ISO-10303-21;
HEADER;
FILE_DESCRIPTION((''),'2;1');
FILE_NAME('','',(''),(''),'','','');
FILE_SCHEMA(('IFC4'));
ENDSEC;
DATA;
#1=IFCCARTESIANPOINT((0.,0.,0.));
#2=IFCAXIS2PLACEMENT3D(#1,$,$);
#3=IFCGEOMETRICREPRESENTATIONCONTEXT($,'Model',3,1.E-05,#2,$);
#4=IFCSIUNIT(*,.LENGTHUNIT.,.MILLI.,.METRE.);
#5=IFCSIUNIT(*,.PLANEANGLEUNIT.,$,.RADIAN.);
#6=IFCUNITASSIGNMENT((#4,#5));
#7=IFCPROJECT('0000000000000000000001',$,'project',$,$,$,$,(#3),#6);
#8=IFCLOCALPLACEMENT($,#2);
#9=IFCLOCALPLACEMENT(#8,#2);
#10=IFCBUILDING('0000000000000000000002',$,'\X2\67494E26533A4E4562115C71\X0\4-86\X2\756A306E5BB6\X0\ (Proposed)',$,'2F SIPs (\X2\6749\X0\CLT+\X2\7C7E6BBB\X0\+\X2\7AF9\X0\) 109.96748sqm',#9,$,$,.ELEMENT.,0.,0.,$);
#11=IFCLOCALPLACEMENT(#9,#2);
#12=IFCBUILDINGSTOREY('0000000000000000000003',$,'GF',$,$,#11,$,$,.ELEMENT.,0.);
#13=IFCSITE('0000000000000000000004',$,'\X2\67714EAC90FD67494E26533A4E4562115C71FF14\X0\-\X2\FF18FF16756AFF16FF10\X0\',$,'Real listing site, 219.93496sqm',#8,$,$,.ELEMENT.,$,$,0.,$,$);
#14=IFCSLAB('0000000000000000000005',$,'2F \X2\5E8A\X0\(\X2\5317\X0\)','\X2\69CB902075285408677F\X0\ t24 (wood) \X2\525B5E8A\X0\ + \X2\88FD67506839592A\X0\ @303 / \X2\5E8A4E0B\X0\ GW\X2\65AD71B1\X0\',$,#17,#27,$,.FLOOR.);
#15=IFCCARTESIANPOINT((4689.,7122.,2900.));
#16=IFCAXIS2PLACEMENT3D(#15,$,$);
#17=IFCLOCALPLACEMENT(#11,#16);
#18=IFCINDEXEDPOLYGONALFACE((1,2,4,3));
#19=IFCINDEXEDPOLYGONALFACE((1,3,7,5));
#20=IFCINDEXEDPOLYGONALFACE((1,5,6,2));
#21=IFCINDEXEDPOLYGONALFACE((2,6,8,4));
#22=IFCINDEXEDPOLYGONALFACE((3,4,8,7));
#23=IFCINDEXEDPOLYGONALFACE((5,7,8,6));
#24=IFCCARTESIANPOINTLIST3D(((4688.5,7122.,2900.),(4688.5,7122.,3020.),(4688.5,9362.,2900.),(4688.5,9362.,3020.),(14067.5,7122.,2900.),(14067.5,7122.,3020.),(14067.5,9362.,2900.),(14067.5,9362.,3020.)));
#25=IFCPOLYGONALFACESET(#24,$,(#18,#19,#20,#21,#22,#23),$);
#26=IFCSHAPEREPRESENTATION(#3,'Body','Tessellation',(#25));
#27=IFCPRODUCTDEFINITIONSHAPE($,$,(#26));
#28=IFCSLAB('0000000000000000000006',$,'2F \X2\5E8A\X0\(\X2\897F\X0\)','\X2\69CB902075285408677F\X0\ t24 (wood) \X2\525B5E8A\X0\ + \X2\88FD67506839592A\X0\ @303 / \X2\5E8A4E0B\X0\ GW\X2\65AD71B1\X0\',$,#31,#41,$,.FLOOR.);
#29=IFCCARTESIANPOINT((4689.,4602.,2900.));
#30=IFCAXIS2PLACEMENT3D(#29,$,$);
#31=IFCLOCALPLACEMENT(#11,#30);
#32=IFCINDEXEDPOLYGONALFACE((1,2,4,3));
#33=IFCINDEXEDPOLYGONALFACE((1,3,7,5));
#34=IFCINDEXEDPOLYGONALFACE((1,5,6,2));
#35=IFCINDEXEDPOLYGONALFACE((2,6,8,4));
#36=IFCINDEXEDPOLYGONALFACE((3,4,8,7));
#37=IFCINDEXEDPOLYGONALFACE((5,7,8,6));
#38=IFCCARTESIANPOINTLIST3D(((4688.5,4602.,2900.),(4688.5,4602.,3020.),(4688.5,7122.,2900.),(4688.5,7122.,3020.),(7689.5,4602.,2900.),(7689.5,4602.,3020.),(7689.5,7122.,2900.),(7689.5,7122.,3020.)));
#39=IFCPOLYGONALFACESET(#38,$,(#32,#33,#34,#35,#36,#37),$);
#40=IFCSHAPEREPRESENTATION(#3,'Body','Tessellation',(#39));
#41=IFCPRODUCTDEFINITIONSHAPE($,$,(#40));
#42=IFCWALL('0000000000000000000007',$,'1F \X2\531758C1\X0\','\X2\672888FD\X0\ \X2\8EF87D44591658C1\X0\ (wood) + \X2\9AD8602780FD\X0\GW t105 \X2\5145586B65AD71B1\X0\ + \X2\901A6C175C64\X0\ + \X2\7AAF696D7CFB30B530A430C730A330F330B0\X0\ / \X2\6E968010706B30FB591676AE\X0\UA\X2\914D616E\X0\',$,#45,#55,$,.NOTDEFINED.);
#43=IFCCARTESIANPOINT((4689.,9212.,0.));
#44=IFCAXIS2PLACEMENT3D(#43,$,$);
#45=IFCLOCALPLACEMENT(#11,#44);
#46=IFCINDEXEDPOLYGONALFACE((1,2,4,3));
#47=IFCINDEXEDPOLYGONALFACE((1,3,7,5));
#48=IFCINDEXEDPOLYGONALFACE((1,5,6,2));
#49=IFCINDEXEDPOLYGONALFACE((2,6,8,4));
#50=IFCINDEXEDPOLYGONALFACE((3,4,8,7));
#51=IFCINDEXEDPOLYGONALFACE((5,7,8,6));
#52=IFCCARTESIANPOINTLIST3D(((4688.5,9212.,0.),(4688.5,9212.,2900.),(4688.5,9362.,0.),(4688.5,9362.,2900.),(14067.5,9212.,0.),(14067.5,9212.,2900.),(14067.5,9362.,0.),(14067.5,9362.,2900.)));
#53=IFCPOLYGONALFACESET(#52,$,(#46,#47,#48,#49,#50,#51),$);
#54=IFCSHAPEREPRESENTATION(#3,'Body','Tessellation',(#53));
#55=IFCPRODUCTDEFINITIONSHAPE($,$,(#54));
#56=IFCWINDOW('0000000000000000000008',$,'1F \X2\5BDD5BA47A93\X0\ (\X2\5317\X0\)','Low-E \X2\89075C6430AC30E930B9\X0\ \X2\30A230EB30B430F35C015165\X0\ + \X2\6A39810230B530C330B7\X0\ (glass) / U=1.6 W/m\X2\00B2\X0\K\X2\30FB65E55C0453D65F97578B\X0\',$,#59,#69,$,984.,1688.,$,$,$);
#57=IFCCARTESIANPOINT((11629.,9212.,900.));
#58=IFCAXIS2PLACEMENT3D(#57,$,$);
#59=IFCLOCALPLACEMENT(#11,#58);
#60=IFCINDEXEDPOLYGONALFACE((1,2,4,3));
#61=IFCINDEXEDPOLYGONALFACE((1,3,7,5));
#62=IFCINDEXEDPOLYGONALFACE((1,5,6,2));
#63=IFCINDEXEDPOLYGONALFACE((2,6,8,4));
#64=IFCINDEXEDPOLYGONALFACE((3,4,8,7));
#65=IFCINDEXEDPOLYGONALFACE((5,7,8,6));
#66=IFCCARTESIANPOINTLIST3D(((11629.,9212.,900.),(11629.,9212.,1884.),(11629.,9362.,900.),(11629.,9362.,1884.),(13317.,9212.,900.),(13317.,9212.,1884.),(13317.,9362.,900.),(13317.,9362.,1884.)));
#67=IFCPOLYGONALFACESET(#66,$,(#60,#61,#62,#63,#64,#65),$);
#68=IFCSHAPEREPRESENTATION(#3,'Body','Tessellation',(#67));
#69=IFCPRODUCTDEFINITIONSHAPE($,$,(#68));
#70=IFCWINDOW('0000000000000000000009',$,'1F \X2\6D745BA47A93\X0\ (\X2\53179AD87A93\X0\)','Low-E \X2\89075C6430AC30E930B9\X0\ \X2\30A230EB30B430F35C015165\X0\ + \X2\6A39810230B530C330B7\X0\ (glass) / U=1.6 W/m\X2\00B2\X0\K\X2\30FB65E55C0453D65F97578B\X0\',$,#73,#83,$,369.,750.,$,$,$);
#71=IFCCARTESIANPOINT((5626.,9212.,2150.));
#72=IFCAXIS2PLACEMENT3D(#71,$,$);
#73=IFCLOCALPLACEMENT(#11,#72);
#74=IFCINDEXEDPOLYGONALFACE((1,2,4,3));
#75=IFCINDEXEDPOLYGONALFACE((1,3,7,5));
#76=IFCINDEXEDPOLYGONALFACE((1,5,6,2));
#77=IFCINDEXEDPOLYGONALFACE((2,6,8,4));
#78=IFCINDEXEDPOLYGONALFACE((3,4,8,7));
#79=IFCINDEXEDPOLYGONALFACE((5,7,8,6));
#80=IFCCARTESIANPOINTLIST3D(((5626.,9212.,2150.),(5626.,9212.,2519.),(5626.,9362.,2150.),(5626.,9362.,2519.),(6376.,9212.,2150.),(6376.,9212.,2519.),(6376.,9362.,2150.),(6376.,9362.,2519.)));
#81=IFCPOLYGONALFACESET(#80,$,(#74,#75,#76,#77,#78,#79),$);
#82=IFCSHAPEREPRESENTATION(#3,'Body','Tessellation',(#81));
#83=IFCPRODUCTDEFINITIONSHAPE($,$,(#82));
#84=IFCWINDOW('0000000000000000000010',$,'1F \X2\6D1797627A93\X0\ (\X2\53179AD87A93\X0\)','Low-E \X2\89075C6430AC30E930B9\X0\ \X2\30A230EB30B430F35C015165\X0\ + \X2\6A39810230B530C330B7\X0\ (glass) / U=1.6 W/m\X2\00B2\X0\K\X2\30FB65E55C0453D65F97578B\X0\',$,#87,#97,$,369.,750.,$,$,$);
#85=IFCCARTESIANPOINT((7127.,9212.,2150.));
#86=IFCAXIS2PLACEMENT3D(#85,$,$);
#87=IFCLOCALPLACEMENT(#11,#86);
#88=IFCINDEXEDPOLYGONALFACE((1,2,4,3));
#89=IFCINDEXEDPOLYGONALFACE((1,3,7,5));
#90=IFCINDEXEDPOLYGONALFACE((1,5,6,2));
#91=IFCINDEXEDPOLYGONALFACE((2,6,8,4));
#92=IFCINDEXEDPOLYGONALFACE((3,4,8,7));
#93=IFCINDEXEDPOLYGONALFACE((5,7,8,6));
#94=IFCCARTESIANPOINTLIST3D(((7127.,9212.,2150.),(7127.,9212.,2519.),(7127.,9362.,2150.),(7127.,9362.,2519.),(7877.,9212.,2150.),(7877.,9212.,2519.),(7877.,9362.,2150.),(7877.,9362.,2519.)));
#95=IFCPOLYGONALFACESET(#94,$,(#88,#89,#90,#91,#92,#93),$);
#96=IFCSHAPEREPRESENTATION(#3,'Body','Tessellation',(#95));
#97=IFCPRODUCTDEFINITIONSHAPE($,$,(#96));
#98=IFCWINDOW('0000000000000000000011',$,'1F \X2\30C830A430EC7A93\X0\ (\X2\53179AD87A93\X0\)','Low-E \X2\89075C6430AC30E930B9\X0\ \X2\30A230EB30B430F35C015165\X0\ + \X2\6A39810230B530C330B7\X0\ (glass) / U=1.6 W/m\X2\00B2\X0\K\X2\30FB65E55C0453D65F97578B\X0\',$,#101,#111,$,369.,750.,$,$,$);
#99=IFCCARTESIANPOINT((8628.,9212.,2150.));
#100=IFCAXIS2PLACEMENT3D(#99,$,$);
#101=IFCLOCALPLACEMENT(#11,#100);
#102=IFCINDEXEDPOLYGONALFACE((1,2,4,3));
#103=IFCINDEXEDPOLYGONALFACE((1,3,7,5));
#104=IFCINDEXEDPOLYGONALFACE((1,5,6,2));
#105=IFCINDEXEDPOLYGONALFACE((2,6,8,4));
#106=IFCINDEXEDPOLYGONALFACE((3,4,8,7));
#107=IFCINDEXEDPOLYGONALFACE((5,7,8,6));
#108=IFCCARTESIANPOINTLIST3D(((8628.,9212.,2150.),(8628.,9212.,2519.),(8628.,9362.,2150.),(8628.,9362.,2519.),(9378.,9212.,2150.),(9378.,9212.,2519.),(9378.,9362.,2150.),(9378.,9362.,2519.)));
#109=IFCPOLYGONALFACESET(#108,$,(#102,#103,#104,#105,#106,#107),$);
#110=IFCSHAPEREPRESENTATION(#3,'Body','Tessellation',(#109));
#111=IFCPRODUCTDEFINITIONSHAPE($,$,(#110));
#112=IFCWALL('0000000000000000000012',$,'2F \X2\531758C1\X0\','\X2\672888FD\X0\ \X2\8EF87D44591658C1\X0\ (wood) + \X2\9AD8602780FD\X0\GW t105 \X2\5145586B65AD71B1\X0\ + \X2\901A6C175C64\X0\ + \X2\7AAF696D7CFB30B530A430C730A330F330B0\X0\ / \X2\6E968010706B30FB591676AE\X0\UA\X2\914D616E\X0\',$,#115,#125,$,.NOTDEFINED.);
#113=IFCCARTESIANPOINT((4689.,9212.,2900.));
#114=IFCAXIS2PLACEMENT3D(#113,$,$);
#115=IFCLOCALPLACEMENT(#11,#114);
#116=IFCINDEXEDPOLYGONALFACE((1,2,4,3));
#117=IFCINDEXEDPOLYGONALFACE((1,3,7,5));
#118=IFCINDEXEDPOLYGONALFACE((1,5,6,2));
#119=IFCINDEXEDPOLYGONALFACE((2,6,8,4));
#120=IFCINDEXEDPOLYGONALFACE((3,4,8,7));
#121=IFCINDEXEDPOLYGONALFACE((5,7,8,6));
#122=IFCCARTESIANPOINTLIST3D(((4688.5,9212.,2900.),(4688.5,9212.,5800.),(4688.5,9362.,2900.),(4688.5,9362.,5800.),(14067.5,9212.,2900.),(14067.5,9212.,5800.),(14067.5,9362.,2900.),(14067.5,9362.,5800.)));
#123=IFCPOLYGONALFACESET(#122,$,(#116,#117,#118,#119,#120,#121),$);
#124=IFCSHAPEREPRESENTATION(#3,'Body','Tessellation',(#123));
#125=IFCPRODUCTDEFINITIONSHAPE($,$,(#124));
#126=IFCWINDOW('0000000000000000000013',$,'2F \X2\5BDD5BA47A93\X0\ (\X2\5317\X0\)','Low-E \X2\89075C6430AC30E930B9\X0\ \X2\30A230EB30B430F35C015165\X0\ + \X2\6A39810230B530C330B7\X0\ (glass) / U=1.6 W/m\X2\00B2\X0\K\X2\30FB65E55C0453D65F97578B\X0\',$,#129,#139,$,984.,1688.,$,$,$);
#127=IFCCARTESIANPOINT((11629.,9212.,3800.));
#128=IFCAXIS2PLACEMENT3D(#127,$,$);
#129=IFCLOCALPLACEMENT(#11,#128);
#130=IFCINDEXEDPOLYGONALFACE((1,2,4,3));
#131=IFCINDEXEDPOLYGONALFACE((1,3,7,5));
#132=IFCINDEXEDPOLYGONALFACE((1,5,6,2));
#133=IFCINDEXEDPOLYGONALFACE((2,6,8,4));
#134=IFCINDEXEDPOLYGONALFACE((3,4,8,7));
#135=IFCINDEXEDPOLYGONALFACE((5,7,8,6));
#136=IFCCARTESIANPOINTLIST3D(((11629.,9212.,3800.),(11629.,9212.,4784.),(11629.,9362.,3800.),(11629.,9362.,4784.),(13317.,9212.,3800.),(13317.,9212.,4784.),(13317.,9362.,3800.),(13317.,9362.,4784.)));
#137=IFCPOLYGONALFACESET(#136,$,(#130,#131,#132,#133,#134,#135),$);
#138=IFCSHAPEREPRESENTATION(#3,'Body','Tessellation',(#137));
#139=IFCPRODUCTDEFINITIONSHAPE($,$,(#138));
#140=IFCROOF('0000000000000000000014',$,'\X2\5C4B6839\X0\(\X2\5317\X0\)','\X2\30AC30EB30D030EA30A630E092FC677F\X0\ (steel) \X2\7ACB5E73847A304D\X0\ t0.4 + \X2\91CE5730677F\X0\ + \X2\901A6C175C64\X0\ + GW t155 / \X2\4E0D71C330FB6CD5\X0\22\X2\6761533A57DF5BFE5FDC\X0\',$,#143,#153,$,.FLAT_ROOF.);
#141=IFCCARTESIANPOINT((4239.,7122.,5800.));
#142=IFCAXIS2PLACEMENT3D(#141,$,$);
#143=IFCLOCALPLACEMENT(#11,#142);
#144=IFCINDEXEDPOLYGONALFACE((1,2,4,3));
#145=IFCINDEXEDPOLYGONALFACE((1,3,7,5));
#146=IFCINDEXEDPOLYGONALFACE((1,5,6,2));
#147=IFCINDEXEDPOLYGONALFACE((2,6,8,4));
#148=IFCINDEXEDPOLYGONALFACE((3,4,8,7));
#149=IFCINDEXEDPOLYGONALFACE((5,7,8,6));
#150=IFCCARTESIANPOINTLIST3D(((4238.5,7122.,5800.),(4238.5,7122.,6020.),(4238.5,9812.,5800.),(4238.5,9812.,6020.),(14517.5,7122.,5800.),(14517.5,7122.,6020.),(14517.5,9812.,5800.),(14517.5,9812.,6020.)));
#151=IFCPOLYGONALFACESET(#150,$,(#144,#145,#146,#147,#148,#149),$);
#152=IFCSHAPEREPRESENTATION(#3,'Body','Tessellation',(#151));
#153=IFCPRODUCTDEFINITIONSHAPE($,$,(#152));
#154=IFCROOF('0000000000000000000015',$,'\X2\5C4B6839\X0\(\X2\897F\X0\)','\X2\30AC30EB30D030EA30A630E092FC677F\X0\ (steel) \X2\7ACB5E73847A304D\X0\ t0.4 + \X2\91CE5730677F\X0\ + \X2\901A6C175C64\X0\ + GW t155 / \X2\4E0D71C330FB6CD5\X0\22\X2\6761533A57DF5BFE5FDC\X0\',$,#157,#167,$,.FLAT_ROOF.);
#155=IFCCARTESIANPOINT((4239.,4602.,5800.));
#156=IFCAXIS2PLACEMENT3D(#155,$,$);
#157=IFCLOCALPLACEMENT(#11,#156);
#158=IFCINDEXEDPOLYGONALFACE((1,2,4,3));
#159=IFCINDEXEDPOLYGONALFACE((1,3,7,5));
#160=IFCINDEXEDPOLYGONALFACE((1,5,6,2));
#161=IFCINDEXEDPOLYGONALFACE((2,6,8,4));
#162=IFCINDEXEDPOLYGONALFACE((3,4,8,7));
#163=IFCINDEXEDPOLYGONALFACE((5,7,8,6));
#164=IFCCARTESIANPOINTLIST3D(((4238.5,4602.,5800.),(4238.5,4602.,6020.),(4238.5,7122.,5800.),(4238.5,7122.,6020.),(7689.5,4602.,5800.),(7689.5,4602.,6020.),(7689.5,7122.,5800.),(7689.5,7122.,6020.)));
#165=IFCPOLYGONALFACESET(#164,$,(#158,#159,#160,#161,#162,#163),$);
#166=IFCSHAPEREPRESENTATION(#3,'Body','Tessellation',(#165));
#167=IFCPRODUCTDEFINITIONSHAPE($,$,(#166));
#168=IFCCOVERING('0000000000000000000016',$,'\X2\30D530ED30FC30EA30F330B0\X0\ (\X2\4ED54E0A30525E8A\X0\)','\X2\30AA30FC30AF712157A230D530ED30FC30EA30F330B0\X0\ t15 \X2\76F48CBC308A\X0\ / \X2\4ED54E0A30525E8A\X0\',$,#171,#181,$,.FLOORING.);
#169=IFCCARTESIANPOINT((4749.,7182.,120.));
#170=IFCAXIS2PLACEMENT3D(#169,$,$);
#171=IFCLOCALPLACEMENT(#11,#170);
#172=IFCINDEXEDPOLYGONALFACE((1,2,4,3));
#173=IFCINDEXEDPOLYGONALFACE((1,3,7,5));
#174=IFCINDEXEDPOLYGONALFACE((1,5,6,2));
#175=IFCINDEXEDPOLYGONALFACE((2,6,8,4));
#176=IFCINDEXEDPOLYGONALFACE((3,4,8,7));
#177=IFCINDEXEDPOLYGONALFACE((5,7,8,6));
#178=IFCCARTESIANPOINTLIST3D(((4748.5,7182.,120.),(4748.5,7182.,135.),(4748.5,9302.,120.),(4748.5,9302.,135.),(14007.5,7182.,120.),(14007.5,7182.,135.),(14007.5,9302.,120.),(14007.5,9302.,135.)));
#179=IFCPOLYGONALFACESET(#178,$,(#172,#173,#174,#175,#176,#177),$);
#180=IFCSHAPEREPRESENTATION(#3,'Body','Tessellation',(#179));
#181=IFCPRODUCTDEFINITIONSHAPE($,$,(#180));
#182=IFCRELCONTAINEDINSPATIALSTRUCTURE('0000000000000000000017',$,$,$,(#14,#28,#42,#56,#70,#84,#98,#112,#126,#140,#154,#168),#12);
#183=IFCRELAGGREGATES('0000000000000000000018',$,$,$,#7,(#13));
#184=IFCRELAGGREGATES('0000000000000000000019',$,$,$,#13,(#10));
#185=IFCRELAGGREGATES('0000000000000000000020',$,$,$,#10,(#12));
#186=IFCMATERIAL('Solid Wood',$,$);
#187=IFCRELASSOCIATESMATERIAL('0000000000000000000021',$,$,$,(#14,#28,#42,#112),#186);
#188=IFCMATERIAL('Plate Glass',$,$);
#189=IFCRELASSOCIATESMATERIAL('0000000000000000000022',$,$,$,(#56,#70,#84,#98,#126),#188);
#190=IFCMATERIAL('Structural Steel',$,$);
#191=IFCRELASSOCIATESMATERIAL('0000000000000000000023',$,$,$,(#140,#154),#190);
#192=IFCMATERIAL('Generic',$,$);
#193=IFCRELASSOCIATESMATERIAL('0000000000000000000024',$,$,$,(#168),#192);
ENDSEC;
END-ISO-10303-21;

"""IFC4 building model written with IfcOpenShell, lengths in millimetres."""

from ifc_helpers import new_model, si_unit, frame, frame_2d, origin, place, context, project, spatial, rectangle, extrude, material, element, fill, save


model = new_model("IFC4")

# Units and contexts
model_context = context("Model", 3, precision=1e-05, world=origin())
ifc_project = project(units=[si_unit("LENGTHUNIT", "METRE", prefix="MILLI"), si_unit("PLANEANGLEUNIT", "RADIAN")], contexts=[model_context])

# Site, building, storey
site_placement = place(None, origin())
site = spatial("IfcSite", under=ifc_project, at=site_placement, Name="東京都杉並区久我山４-８６番６０", ObjectType="Real listing site, 219.93496sqm", CompositionType="ELEMENT", RefElevation=0.0)
building_placement = place(site_placement, origin())
building = spatial("IfcBuilding", under=site, at=building_placement, Name="杉並区久我山4-86番の家 (Proposed)", ObjectType="2F SIPs (杉CLT+籾殻+竹) 109.96748sqm", CompositionType="ELEMENT", ElevationOfRefHeight=0.0, ElevationOfTerrain=0.0)
storey_placement = place(building_placement, origin())
storey = spatial("IfcBuildingStorey", under=building, at=storey_placement, Name="GF", CompositionType="ELEMENT", Elevation=0.0)

# Slabs
ifc_material_1 = material(Name="Solid Wood")
slab_1_placement = place(storey_placement, frame((4689.0, 7122.0, 2900.0)))
element("IfcSlab", 1, at=slab_1_placement, inside=storey, material=ifc_material_1, Name="2F 床(北)", Description="構造用合板 t24 (wood) 剛床 + 製材根太 @303 / 床下 GW断熱", PredefinedType="FLOOR", context=model_context, shape_type="SweptSolid", body=[
    extrude(rectangle(XDim=9379.0, YDim=2240.0, at=frame_2d((4689.0, 1120.0))), frame((4689.0, 7122.0, 2900.0)), (0.0, 0.0, 1.0), 120.0),
])
slab_2_placement = place(storey_placement, frame((4689.0, 4602.0, 2900.0)))
element("IfcSlab", 2, at=slab_2_placement, inside=storey, material=ifc_material_1, Name="2F 床(西)", Description="構造用合板 t24 (wood) 剛床 + 製材根太 @303 / 床下 GW断熱", PredefinedType="FLOOR", context=model_context, shape_type="SweptSolid", body=[
    extrude(rectangle(XDim=3001.0, YDim=2520.0, at=frame_2d((1500.0, 1260.0))), frame((4689.0, 4602.0, 2900.0)), (0.0, 0.0, 1.0), 120.0),
])

# Wall, openings, windows
wall_1_placement = place(storey_placement, frame((4689.0, 9212.0, 0.0)))
wall_1 = element("IfcWall", 3, at=wall_1_placement, inside=storey, material=ifc_material_1, Name="1F 北壁", Description="木製 軸組外壁 (wood) + 高性能GW t105 充填断熱 + 通気層 + 窯業系サイディング / 準耐火・外皮UA配慮", PredefinedType="NOTDEFINED", context=model_context, shape_type="SweptSolid", body=[
    extrude(rectangle(XDim=9379.0, YDim=150.0, at=frame_2d((4689.0, 75.0))), frame((4689.0, 9212.0, 0.0)), (0.0, 0.0, 1.0), 2900.0),
])
opening_1_placement = place(storey_placement, frame((11629.0, 9212.0, 900.0)))
opening_1 = element("IfcOpeningElement", 4, at=opening_1_placement, cuts=wall_1, PredefinedType="NOTDEFINED", context=model_context, shape_type="SweptSolid", body=[
    extrude(rectangle(XDim=1688.0, YDim=150.0, at=frame_2d((844.0, 75.0))), frame((11629.0, 9212.0, 900.0)), (0.0, 0.0, 1.0), 984.0),
])
opening_2_placement = place(storey_placement, frame((5626.0, 9212.0, 2150.0)))
opening_2 = element("IfcOpeningElement", 5, at=opening_2_placement, cuts=wall_1, PredefinedType="NOTDEFINED", context=model_context, shape_type="SweptSolid", body=[
    extrude(rectangle(XDim=750.0, YDim=150.0, at=frame_2d((375.0, 75.0))), frame((5626.0, 9212.0, 2150.0)), (0.0, 0.0, 1.0), 369.0),
])
opening_3_placement = place(storey_placement, frame((7127.0, 9212.0, 2150.0)))
opening_3 = element("IfcOpeningElement", 6, at=opening_3_placement, cuts=wall_1, PredefinedType="NOTDEFINED", context=model_context, shape_type="SweptSolid", body=[
    extrude(rectangle(XDim=750.0, YDim=150.0, at=frame_2d((375.0, 75.0))), frame((7127.0, 9212.0, 2150.0)), (0.0, 0.0, 1.0), 369.0),
])
opening_4_placement = place(storey_placement, frame((8628.0, 9212.0, 2150.0)))
opening_4 = element("IfcOpeningElement", 7, at=opening_4_placement, cuts=wall_1, PredefinedType="NOTDEFINED", context=model_context, shape_type="SweptSolid", body=[
    extrude(rectangle(XDim=750.0, YDim=150.0, at=frame_2d((375.0, 75.0))), frame((8628.0, 9212.0, 2150.0)), (0.0, 0.0, 1.0), 369.0),
])
ifc_material_2 = material(Name="Plate Glass")
window_1_placement = place(storey_placement, frame((11629.0, 9212.0, 900.0)))
window_1 = element("IfcWindow", 8, at=window_1_placement, inside=storey, material=ifc_material_2, Name="1F 寝室窓 (北)", Description="Low-E 複層ガラス アルゴン封入 + 樹脂サッシ (glass) / U=1.6 W/m²K・日射取得型", OverallHeight=984.0, OverallWidth=1688.0, context=model_context, shape_type="SweptSolid", body=[
    extrude(rectangle(XDim=1688.0, YDim=150.0, at=frame_2d((844.0, 75.0))), frame((11629.0, 9212.0, 900.0)), (0.0, 0.0, 1.0), 984.0),
])
fill(opening_1, window_1)
window_2_placement = place(storey_placement, frame((5626.0, 9212.0, 2150.0)))
window_2 = element("IfcWindow", 9, at=window_2_placement, inside=storey, material=ifc_material_2, Name="1F 浴室窓 (北高窓)", Description="Low-E 複層ガラス アルゴン封入 + 樹脂サッシ (glass) / U=1.6 W/m²K・日射取得型", OverallHeight=369.0, OverallWidth=750.0, context=model_context, shape_type="SweptSolid", body=[
    extrude(rectangle(XDim=750.0, YDim=150.0, at=frame_2d((375.0, 75.0))), frame((5626.0, 9212.0, 2150.0)), (0.0, 0.0, 1.0), 369.0),
])
fill(opening_2, window_2)
window_3_placement = place(storey_placement, frame((7127.0, 9212.0, 2150.0)))
window_3 = element("IfcWindow", 10, at=window_3_placement, inside=storey, material=ifc_material_2, Name="1F 洗面窓 (北高窓)", Description="Low-E 複層ガラス アルゴン封入 + 樹脂サッシ (glass) / U=1.6 W/m²K・日射取得型", OverallHeight=369.0, OverallWidth=750.0, context=model_context, shape_type="SweptSolid", body=[
    extrude(rectangle(XDim=750.0, YDim=150.0, at=frame_2d((375.0, 75.0))), frame((7127.0, 9212.0, 2150.0)), (0.0, 0.0, 1.0), 369.0),
])
fill(opening_3, window_3)
window_4_placement = place(storey_placement, frame((8628.0, 9212.0, 2150.0)))
window_4 = element("IfcWindow", 11, at=window_4_placement, inside=storey, material=ifc_material_2, Name="1F トイレ窓 (北高窓)", Description="Low-E 複層ガラス アルゴン封入 + 樹脂サッシ (glass) / U=1.6 W/m²K・日射取得型", OverallHeight=369.0, OverallWidth=750.0, context=model_context, shape_type="SweptSolid", body=[
    extrude(rectangle(XDim=750.0, YDim=150.0, at=frame_2d((375.0, 75.0))), frame((8628.0, 9212.0, 2150.0)), (0.0, 0.0, 1.0), 369.0),
])
fill(opening_4, window_4)

# Wall, opening, window
wall_2_placement = place(storey_placement, frame((4689.0, 9212.0, 2900.0)))
wall_2 = element("IfcWall", 12, at=wall_2_placement, inside=storey, material=ifc_material_1, Name="2F 北壁", Description="木製 軸組外壁 (wood) + 高性能GW t105 充填断熱 + 通気層 + 窯業系サイディング / 準耐火・外皮UA配慮", PredefinedType="NOTDEFINED", context=model_context, shape_type="SweptSolid", body=[
    extrude(rectangle(XDim=9379.0, YDim=150.0, at=frame_2d((4689.0, 75.0))), frame((4689.0, 9212.0, 2900.0)), (0.0, 0.0, 1.0), 2900.0),
])
opening_5_placement = place(storey_placement, frame((11629.0, 9212.0, 3800.0)))
opening_5 = element("IfcOpeningElement", 13, at=opening_5_placement, cuts=wall_2, PredefinedType="NOTDEFINED", context=model_context, shape_type="SweptSolid", body=[
    extrude(rectangle(XDim=1688.0, YDim=150.0, at=frame_2d((844.0, 75.0))), frame((11629.0, 9212.0, 3800.0)), (0.0, 0.0, 1.0), 984.0),
])
window_5_placement = place(storey_placement, frame((11629.0, 9212.0, 3800.0)))
window_5 = element("IfcWindow", 14, at=window_5_placement, inside=storey, material=ifc_material_2, Name="2F 寝室窓 (北)", Description="Low-E 複層ガラス アルゴン封入 + 樹脂サッシ (glass) / U=1.6 W/m²K・日射取得型", OverallHeight=984.0, OverallWidth=1688.0, context=model_context, shape_type="SweptSolid", body=[
    extrude(rectangle(XDim=1688.0, YDim=150.0, at=frame_2d((844.0, 75.0))), frame((11629.0, 9212.0, 3800.0)), (0.0, 0.0, 1.0), 984.0),
])
fill(opening_5, window_5)

# Roofs
ifc_material_3 = material(Name="Structural Steel")
for number, where, name in (
    (15, (4239.0, 7122.0, 5800.0), "屋根(北)"),
):
    element("IfcRoof", number, at=place(storey_placement, frame(where)), inside=storey, material=ifc_material_3, Name=name, Description="ガルバリウム鋼板 (steel) 立平葺き t0.4 + 野地板 + 通気層 + GW t155 / 不燃・法22条区域対応", PredefinedType="FLAT_ROOF", context=model_context, shape_type="SweptSolid", body=[
        extrude(rectangle(XDim=10279.0, YDim=2690.0, at=frame_2d((5139.0, 1345.0))), frame((4239.0, 7122.0, 5800.0)), (0.0, 0.0, 1.0), 220.0),
    ])
roof_placement = place(storey_placement, frame((4239.0, 4602.0, 5800.0)))
element("IfcRoof", 16, at=roof_placement, inside=storey, material=ifc_material_3, Name="屋根(西)", Description="ガルバリウム鋼板 (steel) 立平葺き t0.4 + 野地板 + 通気層 + GW t155 / 不燃・法22条区域対応", PredefinedType="FLAT_ROOF", context=model_context, shape_type="SweptSolid", body=[
    extrude(rectangle(XDim=3451.0, YDim=2520.0, at=frame_2d((1725.0, 1260.0))), frame((4239.0, 4602.0, 5800.0)), (0.0, 0.0, 1.0), 220.0),
])

# Covering
ifc_material_4 = material(Name="Generic")
covering_1_placement = place(storey_placement, frame((4749.0, 7182.0, 120.0)))
element("IfcCovering", 17, at=covering_1_placement, inside=storey, material=ifc_material_4, Name="フローリング (仕上げ床)", Description="オーク無垢フローリング t15 直貼り / 仕上げ床", PredefinedType="FLOORING", context=model_context, shape_type="SweptSolid", body=[
    extrude(rectangle(XDim=9259.0, YDim=2120.0, at=frame_2d((4629.0, 1060.0))), frame((4749.0, 7182.0, 120.0)), (0.0, 0.0, 1.0), 15.0),
])

save(model, "model.ifc")
